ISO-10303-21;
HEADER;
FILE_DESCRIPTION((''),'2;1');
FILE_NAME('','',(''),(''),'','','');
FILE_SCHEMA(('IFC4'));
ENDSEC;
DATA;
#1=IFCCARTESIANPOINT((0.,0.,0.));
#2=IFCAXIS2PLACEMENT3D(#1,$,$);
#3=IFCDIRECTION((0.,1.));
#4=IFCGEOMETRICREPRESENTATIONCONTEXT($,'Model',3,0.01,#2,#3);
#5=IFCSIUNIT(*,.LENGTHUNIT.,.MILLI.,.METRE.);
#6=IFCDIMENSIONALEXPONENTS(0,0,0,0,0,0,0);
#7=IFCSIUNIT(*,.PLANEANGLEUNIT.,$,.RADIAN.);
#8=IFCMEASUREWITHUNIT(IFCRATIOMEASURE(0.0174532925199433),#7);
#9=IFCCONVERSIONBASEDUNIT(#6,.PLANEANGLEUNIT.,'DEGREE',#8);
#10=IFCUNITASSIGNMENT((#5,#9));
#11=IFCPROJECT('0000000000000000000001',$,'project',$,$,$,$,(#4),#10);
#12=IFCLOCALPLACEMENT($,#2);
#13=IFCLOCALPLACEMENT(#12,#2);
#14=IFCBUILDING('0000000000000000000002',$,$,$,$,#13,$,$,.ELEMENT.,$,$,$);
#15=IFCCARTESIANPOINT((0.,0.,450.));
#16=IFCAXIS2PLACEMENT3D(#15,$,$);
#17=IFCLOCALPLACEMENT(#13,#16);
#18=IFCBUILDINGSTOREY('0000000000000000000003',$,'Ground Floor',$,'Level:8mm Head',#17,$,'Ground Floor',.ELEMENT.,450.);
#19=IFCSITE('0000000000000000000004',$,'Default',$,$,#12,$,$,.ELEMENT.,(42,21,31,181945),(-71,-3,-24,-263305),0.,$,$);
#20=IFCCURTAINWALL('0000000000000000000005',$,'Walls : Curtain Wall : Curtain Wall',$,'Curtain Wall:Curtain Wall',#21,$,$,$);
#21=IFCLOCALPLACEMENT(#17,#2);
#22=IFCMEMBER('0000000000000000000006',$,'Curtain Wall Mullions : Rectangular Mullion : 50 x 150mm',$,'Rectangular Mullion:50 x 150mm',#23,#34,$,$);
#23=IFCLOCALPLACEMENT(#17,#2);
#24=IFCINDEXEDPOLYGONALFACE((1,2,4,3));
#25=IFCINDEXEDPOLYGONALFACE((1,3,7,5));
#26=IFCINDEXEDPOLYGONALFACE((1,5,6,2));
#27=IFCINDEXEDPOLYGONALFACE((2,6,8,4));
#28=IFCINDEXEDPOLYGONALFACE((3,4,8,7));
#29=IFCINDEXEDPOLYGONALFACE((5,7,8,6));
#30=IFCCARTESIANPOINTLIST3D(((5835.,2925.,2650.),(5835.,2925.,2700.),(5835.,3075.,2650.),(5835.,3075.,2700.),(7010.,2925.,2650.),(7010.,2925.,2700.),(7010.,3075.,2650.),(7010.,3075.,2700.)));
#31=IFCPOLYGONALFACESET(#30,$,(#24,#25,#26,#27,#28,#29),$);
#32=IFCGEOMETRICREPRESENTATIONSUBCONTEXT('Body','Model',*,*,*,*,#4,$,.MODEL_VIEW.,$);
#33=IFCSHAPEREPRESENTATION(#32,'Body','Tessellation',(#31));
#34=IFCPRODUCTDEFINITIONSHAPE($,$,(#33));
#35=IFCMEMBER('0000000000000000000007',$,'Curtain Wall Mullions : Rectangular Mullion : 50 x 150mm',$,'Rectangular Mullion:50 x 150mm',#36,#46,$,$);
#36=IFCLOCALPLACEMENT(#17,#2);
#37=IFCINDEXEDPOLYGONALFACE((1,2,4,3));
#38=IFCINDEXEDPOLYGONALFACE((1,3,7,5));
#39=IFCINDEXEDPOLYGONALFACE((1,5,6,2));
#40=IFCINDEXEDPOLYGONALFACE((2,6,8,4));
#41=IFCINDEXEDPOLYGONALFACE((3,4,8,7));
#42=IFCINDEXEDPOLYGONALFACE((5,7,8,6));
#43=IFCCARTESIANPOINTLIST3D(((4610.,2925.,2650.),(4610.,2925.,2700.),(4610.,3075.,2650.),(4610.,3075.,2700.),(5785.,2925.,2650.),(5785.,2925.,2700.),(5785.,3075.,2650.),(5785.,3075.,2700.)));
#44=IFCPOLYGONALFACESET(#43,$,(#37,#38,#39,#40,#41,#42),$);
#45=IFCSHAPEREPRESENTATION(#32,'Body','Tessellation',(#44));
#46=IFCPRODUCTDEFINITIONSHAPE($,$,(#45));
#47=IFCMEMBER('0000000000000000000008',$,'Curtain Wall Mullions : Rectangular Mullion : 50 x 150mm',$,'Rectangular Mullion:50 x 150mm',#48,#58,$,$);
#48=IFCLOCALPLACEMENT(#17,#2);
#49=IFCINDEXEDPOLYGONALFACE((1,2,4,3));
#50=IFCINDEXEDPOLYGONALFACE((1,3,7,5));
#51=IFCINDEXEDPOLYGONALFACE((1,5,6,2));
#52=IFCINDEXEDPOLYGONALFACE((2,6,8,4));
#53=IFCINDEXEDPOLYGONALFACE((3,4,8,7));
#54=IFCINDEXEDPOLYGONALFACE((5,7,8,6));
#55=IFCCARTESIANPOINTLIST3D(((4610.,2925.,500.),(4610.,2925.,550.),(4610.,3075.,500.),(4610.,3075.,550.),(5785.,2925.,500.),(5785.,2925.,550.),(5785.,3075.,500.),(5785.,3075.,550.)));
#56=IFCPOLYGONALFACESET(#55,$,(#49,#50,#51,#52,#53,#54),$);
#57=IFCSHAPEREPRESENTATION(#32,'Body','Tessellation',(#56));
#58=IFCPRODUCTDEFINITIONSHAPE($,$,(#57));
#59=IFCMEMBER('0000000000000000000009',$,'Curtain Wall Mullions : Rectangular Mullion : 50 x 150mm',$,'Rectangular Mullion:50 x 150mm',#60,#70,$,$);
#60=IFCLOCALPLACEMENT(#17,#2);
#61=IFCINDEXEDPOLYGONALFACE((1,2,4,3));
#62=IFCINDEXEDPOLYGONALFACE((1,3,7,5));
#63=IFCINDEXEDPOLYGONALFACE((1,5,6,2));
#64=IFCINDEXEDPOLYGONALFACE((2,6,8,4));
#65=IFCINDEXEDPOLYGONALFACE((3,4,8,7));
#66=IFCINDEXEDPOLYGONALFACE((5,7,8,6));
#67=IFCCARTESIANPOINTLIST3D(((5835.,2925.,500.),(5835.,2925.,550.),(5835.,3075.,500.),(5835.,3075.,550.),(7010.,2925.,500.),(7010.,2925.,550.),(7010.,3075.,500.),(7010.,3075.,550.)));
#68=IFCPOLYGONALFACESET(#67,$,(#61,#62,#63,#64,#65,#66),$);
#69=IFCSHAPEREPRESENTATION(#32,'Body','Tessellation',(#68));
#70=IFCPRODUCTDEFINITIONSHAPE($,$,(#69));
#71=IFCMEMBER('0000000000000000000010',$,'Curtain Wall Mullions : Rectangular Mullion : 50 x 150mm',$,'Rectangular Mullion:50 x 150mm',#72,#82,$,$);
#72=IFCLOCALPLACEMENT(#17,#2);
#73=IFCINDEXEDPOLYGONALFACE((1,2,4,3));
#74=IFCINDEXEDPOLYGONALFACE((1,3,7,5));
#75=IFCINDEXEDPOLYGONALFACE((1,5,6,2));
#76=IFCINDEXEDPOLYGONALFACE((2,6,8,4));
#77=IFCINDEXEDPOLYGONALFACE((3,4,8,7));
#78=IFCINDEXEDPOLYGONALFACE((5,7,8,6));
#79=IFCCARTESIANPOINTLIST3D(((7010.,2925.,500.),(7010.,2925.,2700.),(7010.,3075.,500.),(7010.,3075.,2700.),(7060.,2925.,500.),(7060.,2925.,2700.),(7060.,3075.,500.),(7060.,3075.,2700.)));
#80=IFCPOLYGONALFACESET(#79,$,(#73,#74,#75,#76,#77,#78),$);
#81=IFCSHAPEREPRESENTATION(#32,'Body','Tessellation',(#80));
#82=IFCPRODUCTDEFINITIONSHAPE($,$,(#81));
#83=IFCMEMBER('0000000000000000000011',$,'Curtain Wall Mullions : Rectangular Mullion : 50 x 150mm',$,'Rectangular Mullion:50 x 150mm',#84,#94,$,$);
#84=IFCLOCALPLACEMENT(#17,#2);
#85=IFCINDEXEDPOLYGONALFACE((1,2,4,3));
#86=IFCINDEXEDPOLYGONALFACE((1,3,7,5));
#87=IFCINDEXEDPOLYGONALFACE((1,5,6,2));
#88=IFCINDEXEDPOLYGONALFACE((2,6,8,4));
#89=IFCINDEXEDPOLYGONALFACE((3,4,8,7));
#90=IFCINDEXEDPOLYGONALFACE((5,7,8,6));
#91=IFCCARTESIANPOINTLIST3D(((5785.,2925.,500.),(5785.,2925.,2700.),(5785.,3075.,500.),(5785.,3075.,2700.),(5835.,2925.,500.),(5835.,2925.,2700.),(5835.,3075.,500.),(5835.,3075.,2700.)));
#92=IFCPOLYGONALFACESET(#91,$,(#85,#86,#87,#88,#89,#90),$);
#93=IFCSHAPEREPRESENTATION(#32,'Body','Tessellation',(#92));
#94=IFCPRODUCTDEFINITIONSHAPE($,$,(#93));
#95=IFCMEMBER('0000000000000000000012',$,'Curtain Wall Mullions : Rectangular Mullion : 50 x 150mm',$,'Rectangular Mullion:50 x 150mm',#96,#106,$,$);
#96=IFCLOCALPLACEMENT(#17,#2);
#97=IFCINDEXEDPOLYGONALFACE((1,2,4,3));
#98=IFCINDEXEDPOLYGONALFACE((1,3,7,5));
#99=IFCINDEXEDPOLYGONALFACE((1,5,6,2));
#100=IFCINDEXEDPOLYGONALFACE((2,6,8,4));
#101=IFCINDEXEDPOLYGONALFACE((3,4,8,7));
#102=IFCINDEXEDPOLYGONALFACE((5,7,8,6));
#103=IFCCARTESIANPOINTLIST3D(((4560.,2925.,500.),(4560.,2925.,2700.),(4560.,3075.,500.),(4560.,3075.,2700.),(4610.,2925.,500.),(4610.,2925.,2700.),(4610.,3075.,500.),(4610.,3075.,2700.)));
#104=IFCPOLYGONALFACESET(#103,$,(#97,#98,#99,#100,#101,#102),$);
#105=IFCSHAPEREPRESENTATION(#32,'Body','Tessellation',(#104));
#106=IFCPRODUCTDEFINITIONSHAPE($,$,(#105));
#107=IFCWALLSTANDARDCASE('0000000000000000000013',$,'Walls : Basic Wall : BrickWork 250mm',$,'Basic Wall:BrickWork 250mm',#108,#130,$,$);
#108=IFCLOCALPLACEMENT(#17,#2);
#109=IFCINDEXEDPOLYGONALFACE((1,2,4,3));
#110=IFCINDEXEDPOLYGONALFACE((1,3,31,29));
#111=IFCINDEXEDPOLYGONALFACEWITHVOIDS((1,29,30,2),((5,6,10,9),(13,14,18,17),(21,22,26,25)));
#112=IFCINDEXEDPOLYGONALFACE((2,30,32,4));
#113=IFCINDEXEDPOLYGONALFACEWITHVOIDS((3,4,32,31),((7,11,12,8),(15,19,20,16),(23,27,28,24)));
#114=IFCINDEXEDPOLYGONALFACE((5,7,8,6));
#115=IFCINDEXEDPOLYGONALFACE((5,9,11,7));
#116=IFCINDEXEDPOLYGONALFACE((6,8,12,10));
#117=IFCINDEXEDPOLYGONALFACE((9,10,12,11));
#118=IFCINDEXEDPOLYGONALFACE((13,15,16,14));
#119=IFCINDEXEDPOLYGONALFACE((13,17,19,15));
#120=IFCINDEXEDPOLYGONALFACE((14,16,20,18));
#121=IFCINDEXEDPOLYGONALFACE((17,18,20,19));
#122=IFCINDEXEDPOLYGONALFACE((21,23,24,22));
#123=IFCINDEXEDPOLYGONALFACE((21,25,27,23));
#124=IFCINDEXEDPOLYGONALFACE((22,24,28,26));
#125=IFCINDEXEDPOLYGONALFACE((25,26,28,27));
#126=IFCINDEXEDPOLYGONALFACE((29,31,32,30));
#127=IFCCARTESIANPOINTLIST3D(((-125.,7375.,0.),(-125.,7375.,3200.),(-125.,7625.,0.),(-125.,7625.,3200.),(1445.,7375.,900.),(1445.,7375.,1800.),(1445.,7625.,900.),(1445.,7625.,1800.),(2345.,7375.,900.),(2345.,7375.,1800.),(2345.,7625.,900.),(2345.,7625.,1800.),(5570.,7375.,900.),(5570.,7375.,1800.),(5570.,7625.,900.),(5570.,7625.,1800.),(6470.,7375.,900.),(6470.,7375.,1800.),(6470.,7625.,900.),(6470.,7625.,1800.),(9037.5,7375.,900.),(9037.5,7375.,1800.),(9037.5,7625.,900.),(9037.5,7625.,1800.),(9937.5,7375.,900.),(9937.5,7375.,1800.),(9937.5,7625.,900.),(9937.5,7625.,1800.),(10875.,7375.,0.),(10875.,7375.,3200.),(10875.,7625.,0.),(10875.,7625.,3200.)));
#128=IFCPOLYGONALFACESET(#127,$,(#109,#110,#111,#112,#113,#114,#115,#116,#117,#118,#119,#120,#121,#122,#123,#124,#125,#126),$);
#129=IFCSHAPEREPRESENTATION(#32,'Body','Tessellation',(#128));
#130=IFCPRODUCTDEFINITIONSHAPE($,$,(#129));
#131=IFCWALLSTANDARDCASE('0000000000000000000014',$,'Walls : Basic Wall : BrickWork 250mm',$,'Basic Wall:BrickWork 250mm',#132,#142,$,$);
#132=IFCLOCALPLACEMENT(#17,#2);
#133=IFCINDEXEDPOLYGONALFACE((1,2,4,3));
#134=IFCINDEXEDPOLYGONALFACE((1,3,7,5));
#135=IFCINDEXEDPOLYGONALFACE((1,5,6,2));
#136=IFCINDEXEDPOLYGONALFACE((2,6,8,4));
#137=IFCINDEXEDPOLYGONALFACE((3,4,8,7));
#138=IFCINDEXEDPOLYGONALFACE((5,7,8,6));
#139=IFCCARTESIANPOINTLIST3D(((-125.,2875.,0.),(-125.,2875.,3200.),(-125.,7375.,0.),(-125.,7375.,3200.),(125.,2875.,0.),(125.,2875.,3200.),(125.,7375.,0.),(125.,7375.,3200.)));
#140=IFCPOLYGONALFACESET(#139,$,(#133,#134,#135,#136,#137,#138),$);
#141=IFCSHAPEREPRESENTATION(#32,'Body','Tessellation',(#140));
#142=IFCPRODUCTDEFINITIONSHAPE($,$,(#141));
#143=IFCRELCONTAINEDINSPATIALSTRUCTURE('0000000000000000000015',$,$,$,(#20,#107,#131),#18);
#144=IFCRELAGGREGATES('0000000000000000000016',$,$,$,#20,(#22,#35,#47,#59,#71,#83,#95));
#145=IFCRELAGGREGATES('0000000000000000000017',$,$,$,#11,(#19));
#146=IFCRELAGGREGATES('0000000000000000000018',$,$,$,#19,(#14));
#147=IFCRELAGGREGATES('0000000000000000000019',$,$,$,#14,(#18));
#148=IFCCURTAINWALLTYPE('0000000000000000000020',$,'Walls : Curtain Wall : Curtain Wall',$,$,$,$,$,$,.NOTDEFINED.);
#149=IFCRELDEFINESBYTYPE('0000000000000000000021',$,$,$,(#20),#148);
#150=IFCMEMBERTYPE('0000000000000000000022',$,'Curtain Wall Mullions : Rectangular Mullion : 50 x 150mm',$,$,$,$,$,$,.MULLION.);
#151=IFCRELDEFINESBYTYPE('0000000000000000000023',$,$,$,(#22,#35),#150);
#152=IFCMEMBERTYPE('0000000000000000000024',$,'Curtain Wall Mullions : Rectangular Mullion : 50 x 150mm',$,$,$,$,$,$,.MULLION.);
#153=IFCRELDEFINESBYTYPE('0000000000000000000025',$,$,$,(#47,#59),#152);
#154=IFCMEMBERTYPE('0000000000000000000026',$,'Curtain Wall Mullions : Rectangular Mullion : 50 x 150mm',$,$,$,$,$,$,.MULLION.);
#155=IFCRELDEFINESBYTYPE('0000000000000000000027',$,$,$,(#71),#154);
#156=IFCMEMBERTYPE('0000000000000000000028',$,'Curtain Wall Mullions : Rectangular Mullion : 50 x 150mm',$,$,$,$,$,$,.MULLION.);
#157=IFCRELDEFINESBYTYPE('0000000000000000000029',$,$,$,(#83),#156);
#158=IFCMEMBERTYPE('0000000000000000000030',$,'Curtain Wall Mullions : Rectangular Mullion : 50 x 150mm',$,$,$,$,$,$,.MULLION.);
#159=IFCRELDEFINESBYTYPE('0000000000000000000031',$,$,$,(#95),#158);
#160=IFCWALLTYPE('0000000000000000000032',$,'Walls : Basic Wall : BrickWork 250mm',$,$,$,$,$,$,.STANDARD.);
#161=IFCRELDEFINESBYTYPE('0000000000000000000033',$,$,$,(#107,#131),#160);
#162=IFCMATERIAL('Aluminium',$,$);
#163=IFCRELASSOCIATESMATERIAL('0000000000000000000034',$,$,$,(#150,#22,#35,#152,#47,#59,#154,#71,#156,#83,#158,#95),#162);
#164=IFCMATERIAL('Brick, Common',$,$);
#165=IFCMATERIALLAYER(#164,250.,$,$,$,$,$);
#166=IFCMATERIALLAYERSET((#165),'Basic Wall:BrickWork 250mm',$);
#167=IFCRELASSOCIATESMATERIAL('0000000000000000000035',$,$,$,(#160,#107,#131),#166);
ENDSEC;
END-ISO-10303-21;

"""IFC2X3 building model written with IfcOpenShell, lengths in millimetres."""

from ifc_helpers import new_model, entity, si_unit, converted_unit, direction, frame, frame_2d, origin, origin_2d_with_axis, place, context, subcontext, project, spatial, rectangle, extrude, clip, halfspace, source, transform, mapped, material, layer, layer_set, layer_usage, type_object, type_shapes, element, aggregate, save


model = new_model("IFC2X3")

# Units and contexts
model_context = context("Model", 3, precision=0.01, world=origin(), true_north=direction((0.0, 1.0)))
body_context = subcontext(model_context, "Body", "Model", "MODEL_VIEW")
ifc_project = project(units=[si_unit("LENGTHUNIT", "METRE", prefix="MILLI"), converted_unit("PLANEANGLEUNIT", "DEGREE", entity("IfcRatioMeasure", 0.0174532925199433), si_unit("PLANEANGLEUNIT", "RADIAN"), dimensions=[0, 0, 0, 0, 0, 0, 0])], contexts=[model_context])

# Site, building, storey
site_placement = place(None, origin())
site = spatial("IfcSite", under=ifc_project, at=site_placement, Name="Default", CompositionType="ELEMENT", RefLatitude=(42, 21, 31, 181945), RefLongitude=(-71, -3, -24, -263305), RefElevation=0.0)
building_placement = place(site_placement, origin())
building = spatial("IfcBuilding", under=site, at=building_placement, CompositionType="ELEMENT")
storey_placement = place(building_placement, frame((0.0, 0.0, 450.0)))
storey = spatial("IfcBuildingStorey", under=building, at=storey_placement, Name="Ground Floor", ObjectType="Level:8mm Head", LongName="Ground Floor", CompositionType="ELEMENT", Elevation=450.0)

# Curtain wall, members
curtain_wall_type = type_object("IfcCurtainWallType", Name="Walls : Curtain Wall : Curtain Wall", PredefinedType="NOTDEFINED")
curtain_wall_placement = place(storey_placement, frame((0.0, 0.0, -450.0)))
curtain_wall = element("IfcCurtainWall", 1, at=curtain_wall_placement, inside=storey, type_object=curtain_wall_type, Name="Walls : Curtain Wall : Curtain Wall", ObjectType="Curtain Wall:Curtain Wall")
ifc_material_1 = material(Name="Aluminium")
member_type_1 = type_object("IfcMemberType", Name="Curtain Wall Mullions : Rectangular Mullion : 50 x 150mm", PredefinedType="MULLION", material=ifc_material_1)
shared_shape_1 = source(origin(), body_context, "Body", "SweptSolid", [
    extrude(rectangle(XDim=150.0, YDim=50.0, at=origin_2d_with_axis()), frame((-25.0, 0.0, -1175.0), z_axis=(0.0, 0.0, 1.0), x_axis=(0.0, -1.0, 0.0)), (0.0, 0.0, 1.0), 1175.0),
])
type_shapes(member_type_1, [shared_shape_1])
member_1_placement = place(storey_placement, frame((7010.0, 3000.0, 2700.0), z_axis=(1.0, 0.0, 0.0), x_axis=(0.0, 0.0, 1.0)))
member_1 = element("IfcMember", 2, at=member_1_placement, type_object=member_type_1, material=ifc_material_1, Name="Curtain Wall Mullions : Rectangular Mullion : 50 x 150mm", ObjectType="Rectangular Mullion:50 x 150mm", context=body_context, shape_type="MappedRepresentation", body=[
    mapped(shared_shape_1, transform((0.0, 0.0, 0.0), scale=1.0)),
])
member_2_placement = place(storey_placement, frame((5785.0, 3000.0, 2700.0), z_axis=(1.0, 0.0, 0.0), x_axis=(0.0, 0.0, 1.0)))
member_2 = element("IfcMember", 3, at=member_2_placement, type_object=member_type_1, material=ifc_material_1, Name="Curtain Wall Mullions : Rectangular Mullion : 50 x 150mm", ObjectType="Rectangular Mullion:50 x 150mm", context=body_context, shape_type="MappedRepresentation", body=[
    mapped(shared_shape_1, transform((0.0, 0.0, 0.0), scale=1.0)),
])
member_type_2 = type_object("IfcMemberType", Name="Curtain Wall Mullions : Rectangular Mullion : 50 x 150mm", PredefinedType="MULLION", material=ifc_material_1)
shared_shape_2 = source(origin(), body_context, "Body", "SweptSolid", [
    extrude(rectangle(XDim=150.0, YDim=50.0, at=origin_2d_with_axis()), frame((-25.0, 0.0, -1175.0), z_axis=(0.0, 0.0, 1.0), x_axis=(0.0, -1.0, 0.0)), (0.0, 0.0, 1.0), 1175.0),
])
type_shapes(member_type_2, [shared_shape_2])
member_3_placement = place(storey_placement, frame((4610.0, 3000.0, 500.0), z_axis=(-1.0, 0.0, 0.0), x_axis=(0.0, 0.0, -1.0)))
member_3 = element("IfcMember", 4, at=member_3_placement, type_object=member_type_2, material=ifc_material_1, Name="Curtain Wall Mullions : Rectangular Mullion : 50 x 150mm", ObjectType="Rectangular Mullion:50 x 150mm", context=body_context, shape_type="MappedRepresentation", body=[
    mapped(shared_shape_2, transform((0.0, 0.0, 0.0), scale=1.0)),
])
member_4_placement = place(storey_placement, frame((5835.0, 3000.0, 500.0), z_axis=(-1.0, 0.0, 0.0), x_axis=(0.0, 0.0, -1.0)))
member_4 = element("IfcMember", 5, at=member_4_placement, type_object=member_type_2, material=ifc_material_1, Name="Curtain Wall Mullions : Rectangular Mullion : 50 x 150mm", ObjectType="Rectangular Mullion:50 x 150mm", context=body_context, shape_type="MappedRepresentation", body=[
    mapped(shared_shape_2, transform((0.0, 0.0, 0.0), scale=1.0)),
])
member_type_3 = type_object("IfcMemberType", Name="Curtain Wall Mullions : Rectangular Mullion : 50 x 150mm", PredefinedType="MULLION", material=ifc_material_1)
shared_shape_3 = source(origin(), body_context, "Body", "SweptSolid", [
    extrude(rectangle(XDim=150.0, YDim=50.0, at=origin_2d_with_axis()), frame((-25.0, 0.0, -2200.0), z_axis=(0.0, 0.0, 1.0), x_axis=(0.0, -1.0, 0.0)), (0.0, 0.0, 1.0), 2200.0),
])
type_shapes(member_type_3, [shared_shape_3])
member_5_placement = place(storey_placement, frame((7060.0, 3000.0, 500.0), z_axis=(0.0, 0.0, -1.0), x_axis=(1.0, 0.0, 0.0)))
member_5 = element("IfcMember", 6, at=member_5_placement, type_object=member_type_3, material=ifc_material_1, Name="Curtain Wall Mullions : Rectangular Mullion : 50 x 150mm", ObjectType="Rectangular Mullion:50 x 150mm", context=body_context, shape_type="MappedRepresentation", body=[
    mapped(shared_shape_3, transform((0.0, 0.0, 0.0), scale=1.0)),
])
member_type_4 = type_object("IfcMemberType", Name="Curtain Wall Mullions : Rectangular Mullion : 50 x 150mm", PredefinedType="MULLION", material=ifc_material_1)
shared_shape_4 = source(origin(), body_context, "Body", "SweptSolid", [
    extrude(rectangle(XDim=150.0, YDim=50.0, at=origin_2d_with_axis()), frame((0.0, 0.0, -2200.0), z_axis=(0.0, 0.0, 1.0), x_axis=(0.0, -1.0, 0.0)), (0.0, 0.0, 1.0), 2200.0),
])
type_shapes(member_type_4, [shared_shape_4])
member_6_placement = place(storey_placement, frame((5810.0, 3000.0, 500.0), z_axis=(0.0, 0.0, -1.0), x_axis=(1.0, 0.0, 0.0)))
member_6 = element("IfcMember", 7, at=member_6_placement, type_object=member_type_4, material=ifc_material_1, Name="Curtain Wall Mullions : Rectangular Mullion : 50 x 150mm", ObjectType="Rectangular Mullion:50 x 150mm", context=body_context, shape_type="MappedRepresentation", body=[
    mapped(shared_shape_4, transform((0.0, 0.0, 0.0), scale=1.0)),
])
member_type_5 = type_object("IfcMemberType", Name="Curtain Wall Mullions : Rectangular Mullion : 50 x 150mm", PredefinedType="MULLION", material=ifc_material_1)
shared_shape_5 = source(origin(), body_context, "Body", "SweptSolid", [
    extrude(rectangle(XDim=150.0, YDim=50.0, at=origin_2d_with_axis()), frame((-25.0, 0.0, -2200.0), z_axis=(0.0, 0.0, 1.0), x_axis=(0.0, -1.0, 0.0)), (0.0, 0.0, 1.0), 2200.0),
])
type_shapes(member_type_5, [shared_shape_5])
member_7_placement = place(storey_placement, frame((4560.0, 3000.0, 2700.0), z_axis=(0.0, 0.0, 1.0), x_axis=(-1.0, 0.0, 0.0)))
member_7 = element("IfcMember", 8, at=member_7_placement, type_object=member_type_5, material=ifc_material_1, Name="Curtain Wall Mullions : Rectangular Mullion : 50 x 150mm", ObjectType="Rectangular Mullion:50 x 150mm", context=body_context, shape_type="MappedRepresentation", body=[
    mapped(shared_shape_5, transform((0.0, 0.0, 0.0), scale=1.0)),
])
aggregate(curtain_wall, [member_1, member_2, member_3, member_4, member_5, member_6, member_7])

# Wall, openings
ifc_material_2 = material(Name="Brick, Common")
ifc_layer = layer(ifc_material_2, 250.0)
ifc_layer_set = layer_set([ifc_layer], Name="Basic Wall:BrickWork 250mm")
ifc_layer_usage_1 = layer_usage(ifc_layer_set, "AXIS2", "POSITIVE", -125.0)
wall_type = type_object("IfcWallType", Name="Walls : Basic Wall : BrickWork 250mm", PredefinedType="STANDARD", material=ifc_layer_set)
wall_1_placement = place(storey_placement, frame((-125.0, 7500.0, 0.0)))
wall_1 = element("IfcWallStandardCase", 9, at=wall_1_placement, inside=storey, type_object=wall_type, material=ifc_layer_usage_1, Name="Walls : Basic Wall : BrickWork 250mm", ObjectType="Basic Wall:BrickWork 250mm", context=body_context, shape_type="Clipping", body=[
    clip(extrude(rectangle(XDim=11000.0, YDim=250.0, at=frame_2d((5500.0, 0.0), x_axis=(-1.0, 0.0))), origin(), (0.0, 0.0, 1.0), 3200.0), halfspace(origin(), True)),
])
opening_1_placement = place(wall_1_placement, frame((2470.0, 125.0, 900.0)))
element("IfcOpeningElement", 10, at=opening_1_placement, cuts=wall_1, ObjectType="Opening", context=body_context, shape_type="SweptSolid", body=[
    extrude(rectangle(XDim=900.0, YDim=900.0, at=frame_2d((450.0, 450.0), x_axis=(-1.0, 0.0))), frame((0.0, 0.0, 0.0), z_axis=(0.0, -1.0, 0.0), x_axis=(0.0, 0.0, 1.0)), (0.0, 0.0, 1.0), 250.0),
])
opening_2_placement = place(wall_1_placement, frame((6595.0, 125.0, 900.0)))
element("IfcOpeningElement", 11, at=opening_2_placement, cuts=wall_1, ObjectType="Opening", context=body_context, shape_type="SweptSolid", body=[
    extrude(rectangle(XDim=900.0, YDim=900.0, at=frame_2d((450.0, 450.0), x_axis=(-1.0, 0.0))), frame((0.0, 0.0, 0.0), z_axis=(0.0, -1.0, 0.0), x_axis=(0.0, 0.0, 1.0)), (0.0, 0.0, 1.0), 250.0),
])
opening_3_placement = place(wall_1_placement, frame((10062.5, 125.0, 900.0)))
element("IfcOpeningElement", 12, at=opening_3_placement, cuts=wall_1, ObjectType="Opening", context=body_context, shape_type="SweptSolid", body=[
    extrude(rectangle(XDim=900.0, YDim=900.0, at=frame_2d((450.0, 450.0), x_axis=(-1.0, 0.0))), frame((0.0, 0.0, 0.0), z_axis=(0.0, -1.0, 0.0), x_axis=(0.0, 0.0, 1.0)), (0.0, 0.0, 1.0), 250.0),
])

# Wall
ifc_layer_usage_2 = layer_usage(ifc_layer_set, "AXIS2", "POSITIVE", -125.0)
wall_2_placement = place(storey_placement, frame((0.0, 7375.0, 0.0), z_axis=(0.0, 0.0, 1.0), x_axis=(0.0, -1.0, 0.0)))
element("IfcWallStandardCase", 13, at=wall_2_placement, inside=storey, type_object=wall_type, material=ifc_layer_usage_2, Name="Walls : Basic Wall : BrickWork 250mm", ObjectType="Basic Wall:BrickWork 250mm", context=body_context, shape_type="Clipping", body=[
    clip(extrude(rectangle(XDim=4500.0, YDim=250.0, at=frame_2d((2250.0, 0.0), x_axis=(-1.0, 0.0))), origin(), (0.0, 0.0, 1.0), 3200.0), halfspace(origin(), True)),
])

save(model, "model.ifc")
